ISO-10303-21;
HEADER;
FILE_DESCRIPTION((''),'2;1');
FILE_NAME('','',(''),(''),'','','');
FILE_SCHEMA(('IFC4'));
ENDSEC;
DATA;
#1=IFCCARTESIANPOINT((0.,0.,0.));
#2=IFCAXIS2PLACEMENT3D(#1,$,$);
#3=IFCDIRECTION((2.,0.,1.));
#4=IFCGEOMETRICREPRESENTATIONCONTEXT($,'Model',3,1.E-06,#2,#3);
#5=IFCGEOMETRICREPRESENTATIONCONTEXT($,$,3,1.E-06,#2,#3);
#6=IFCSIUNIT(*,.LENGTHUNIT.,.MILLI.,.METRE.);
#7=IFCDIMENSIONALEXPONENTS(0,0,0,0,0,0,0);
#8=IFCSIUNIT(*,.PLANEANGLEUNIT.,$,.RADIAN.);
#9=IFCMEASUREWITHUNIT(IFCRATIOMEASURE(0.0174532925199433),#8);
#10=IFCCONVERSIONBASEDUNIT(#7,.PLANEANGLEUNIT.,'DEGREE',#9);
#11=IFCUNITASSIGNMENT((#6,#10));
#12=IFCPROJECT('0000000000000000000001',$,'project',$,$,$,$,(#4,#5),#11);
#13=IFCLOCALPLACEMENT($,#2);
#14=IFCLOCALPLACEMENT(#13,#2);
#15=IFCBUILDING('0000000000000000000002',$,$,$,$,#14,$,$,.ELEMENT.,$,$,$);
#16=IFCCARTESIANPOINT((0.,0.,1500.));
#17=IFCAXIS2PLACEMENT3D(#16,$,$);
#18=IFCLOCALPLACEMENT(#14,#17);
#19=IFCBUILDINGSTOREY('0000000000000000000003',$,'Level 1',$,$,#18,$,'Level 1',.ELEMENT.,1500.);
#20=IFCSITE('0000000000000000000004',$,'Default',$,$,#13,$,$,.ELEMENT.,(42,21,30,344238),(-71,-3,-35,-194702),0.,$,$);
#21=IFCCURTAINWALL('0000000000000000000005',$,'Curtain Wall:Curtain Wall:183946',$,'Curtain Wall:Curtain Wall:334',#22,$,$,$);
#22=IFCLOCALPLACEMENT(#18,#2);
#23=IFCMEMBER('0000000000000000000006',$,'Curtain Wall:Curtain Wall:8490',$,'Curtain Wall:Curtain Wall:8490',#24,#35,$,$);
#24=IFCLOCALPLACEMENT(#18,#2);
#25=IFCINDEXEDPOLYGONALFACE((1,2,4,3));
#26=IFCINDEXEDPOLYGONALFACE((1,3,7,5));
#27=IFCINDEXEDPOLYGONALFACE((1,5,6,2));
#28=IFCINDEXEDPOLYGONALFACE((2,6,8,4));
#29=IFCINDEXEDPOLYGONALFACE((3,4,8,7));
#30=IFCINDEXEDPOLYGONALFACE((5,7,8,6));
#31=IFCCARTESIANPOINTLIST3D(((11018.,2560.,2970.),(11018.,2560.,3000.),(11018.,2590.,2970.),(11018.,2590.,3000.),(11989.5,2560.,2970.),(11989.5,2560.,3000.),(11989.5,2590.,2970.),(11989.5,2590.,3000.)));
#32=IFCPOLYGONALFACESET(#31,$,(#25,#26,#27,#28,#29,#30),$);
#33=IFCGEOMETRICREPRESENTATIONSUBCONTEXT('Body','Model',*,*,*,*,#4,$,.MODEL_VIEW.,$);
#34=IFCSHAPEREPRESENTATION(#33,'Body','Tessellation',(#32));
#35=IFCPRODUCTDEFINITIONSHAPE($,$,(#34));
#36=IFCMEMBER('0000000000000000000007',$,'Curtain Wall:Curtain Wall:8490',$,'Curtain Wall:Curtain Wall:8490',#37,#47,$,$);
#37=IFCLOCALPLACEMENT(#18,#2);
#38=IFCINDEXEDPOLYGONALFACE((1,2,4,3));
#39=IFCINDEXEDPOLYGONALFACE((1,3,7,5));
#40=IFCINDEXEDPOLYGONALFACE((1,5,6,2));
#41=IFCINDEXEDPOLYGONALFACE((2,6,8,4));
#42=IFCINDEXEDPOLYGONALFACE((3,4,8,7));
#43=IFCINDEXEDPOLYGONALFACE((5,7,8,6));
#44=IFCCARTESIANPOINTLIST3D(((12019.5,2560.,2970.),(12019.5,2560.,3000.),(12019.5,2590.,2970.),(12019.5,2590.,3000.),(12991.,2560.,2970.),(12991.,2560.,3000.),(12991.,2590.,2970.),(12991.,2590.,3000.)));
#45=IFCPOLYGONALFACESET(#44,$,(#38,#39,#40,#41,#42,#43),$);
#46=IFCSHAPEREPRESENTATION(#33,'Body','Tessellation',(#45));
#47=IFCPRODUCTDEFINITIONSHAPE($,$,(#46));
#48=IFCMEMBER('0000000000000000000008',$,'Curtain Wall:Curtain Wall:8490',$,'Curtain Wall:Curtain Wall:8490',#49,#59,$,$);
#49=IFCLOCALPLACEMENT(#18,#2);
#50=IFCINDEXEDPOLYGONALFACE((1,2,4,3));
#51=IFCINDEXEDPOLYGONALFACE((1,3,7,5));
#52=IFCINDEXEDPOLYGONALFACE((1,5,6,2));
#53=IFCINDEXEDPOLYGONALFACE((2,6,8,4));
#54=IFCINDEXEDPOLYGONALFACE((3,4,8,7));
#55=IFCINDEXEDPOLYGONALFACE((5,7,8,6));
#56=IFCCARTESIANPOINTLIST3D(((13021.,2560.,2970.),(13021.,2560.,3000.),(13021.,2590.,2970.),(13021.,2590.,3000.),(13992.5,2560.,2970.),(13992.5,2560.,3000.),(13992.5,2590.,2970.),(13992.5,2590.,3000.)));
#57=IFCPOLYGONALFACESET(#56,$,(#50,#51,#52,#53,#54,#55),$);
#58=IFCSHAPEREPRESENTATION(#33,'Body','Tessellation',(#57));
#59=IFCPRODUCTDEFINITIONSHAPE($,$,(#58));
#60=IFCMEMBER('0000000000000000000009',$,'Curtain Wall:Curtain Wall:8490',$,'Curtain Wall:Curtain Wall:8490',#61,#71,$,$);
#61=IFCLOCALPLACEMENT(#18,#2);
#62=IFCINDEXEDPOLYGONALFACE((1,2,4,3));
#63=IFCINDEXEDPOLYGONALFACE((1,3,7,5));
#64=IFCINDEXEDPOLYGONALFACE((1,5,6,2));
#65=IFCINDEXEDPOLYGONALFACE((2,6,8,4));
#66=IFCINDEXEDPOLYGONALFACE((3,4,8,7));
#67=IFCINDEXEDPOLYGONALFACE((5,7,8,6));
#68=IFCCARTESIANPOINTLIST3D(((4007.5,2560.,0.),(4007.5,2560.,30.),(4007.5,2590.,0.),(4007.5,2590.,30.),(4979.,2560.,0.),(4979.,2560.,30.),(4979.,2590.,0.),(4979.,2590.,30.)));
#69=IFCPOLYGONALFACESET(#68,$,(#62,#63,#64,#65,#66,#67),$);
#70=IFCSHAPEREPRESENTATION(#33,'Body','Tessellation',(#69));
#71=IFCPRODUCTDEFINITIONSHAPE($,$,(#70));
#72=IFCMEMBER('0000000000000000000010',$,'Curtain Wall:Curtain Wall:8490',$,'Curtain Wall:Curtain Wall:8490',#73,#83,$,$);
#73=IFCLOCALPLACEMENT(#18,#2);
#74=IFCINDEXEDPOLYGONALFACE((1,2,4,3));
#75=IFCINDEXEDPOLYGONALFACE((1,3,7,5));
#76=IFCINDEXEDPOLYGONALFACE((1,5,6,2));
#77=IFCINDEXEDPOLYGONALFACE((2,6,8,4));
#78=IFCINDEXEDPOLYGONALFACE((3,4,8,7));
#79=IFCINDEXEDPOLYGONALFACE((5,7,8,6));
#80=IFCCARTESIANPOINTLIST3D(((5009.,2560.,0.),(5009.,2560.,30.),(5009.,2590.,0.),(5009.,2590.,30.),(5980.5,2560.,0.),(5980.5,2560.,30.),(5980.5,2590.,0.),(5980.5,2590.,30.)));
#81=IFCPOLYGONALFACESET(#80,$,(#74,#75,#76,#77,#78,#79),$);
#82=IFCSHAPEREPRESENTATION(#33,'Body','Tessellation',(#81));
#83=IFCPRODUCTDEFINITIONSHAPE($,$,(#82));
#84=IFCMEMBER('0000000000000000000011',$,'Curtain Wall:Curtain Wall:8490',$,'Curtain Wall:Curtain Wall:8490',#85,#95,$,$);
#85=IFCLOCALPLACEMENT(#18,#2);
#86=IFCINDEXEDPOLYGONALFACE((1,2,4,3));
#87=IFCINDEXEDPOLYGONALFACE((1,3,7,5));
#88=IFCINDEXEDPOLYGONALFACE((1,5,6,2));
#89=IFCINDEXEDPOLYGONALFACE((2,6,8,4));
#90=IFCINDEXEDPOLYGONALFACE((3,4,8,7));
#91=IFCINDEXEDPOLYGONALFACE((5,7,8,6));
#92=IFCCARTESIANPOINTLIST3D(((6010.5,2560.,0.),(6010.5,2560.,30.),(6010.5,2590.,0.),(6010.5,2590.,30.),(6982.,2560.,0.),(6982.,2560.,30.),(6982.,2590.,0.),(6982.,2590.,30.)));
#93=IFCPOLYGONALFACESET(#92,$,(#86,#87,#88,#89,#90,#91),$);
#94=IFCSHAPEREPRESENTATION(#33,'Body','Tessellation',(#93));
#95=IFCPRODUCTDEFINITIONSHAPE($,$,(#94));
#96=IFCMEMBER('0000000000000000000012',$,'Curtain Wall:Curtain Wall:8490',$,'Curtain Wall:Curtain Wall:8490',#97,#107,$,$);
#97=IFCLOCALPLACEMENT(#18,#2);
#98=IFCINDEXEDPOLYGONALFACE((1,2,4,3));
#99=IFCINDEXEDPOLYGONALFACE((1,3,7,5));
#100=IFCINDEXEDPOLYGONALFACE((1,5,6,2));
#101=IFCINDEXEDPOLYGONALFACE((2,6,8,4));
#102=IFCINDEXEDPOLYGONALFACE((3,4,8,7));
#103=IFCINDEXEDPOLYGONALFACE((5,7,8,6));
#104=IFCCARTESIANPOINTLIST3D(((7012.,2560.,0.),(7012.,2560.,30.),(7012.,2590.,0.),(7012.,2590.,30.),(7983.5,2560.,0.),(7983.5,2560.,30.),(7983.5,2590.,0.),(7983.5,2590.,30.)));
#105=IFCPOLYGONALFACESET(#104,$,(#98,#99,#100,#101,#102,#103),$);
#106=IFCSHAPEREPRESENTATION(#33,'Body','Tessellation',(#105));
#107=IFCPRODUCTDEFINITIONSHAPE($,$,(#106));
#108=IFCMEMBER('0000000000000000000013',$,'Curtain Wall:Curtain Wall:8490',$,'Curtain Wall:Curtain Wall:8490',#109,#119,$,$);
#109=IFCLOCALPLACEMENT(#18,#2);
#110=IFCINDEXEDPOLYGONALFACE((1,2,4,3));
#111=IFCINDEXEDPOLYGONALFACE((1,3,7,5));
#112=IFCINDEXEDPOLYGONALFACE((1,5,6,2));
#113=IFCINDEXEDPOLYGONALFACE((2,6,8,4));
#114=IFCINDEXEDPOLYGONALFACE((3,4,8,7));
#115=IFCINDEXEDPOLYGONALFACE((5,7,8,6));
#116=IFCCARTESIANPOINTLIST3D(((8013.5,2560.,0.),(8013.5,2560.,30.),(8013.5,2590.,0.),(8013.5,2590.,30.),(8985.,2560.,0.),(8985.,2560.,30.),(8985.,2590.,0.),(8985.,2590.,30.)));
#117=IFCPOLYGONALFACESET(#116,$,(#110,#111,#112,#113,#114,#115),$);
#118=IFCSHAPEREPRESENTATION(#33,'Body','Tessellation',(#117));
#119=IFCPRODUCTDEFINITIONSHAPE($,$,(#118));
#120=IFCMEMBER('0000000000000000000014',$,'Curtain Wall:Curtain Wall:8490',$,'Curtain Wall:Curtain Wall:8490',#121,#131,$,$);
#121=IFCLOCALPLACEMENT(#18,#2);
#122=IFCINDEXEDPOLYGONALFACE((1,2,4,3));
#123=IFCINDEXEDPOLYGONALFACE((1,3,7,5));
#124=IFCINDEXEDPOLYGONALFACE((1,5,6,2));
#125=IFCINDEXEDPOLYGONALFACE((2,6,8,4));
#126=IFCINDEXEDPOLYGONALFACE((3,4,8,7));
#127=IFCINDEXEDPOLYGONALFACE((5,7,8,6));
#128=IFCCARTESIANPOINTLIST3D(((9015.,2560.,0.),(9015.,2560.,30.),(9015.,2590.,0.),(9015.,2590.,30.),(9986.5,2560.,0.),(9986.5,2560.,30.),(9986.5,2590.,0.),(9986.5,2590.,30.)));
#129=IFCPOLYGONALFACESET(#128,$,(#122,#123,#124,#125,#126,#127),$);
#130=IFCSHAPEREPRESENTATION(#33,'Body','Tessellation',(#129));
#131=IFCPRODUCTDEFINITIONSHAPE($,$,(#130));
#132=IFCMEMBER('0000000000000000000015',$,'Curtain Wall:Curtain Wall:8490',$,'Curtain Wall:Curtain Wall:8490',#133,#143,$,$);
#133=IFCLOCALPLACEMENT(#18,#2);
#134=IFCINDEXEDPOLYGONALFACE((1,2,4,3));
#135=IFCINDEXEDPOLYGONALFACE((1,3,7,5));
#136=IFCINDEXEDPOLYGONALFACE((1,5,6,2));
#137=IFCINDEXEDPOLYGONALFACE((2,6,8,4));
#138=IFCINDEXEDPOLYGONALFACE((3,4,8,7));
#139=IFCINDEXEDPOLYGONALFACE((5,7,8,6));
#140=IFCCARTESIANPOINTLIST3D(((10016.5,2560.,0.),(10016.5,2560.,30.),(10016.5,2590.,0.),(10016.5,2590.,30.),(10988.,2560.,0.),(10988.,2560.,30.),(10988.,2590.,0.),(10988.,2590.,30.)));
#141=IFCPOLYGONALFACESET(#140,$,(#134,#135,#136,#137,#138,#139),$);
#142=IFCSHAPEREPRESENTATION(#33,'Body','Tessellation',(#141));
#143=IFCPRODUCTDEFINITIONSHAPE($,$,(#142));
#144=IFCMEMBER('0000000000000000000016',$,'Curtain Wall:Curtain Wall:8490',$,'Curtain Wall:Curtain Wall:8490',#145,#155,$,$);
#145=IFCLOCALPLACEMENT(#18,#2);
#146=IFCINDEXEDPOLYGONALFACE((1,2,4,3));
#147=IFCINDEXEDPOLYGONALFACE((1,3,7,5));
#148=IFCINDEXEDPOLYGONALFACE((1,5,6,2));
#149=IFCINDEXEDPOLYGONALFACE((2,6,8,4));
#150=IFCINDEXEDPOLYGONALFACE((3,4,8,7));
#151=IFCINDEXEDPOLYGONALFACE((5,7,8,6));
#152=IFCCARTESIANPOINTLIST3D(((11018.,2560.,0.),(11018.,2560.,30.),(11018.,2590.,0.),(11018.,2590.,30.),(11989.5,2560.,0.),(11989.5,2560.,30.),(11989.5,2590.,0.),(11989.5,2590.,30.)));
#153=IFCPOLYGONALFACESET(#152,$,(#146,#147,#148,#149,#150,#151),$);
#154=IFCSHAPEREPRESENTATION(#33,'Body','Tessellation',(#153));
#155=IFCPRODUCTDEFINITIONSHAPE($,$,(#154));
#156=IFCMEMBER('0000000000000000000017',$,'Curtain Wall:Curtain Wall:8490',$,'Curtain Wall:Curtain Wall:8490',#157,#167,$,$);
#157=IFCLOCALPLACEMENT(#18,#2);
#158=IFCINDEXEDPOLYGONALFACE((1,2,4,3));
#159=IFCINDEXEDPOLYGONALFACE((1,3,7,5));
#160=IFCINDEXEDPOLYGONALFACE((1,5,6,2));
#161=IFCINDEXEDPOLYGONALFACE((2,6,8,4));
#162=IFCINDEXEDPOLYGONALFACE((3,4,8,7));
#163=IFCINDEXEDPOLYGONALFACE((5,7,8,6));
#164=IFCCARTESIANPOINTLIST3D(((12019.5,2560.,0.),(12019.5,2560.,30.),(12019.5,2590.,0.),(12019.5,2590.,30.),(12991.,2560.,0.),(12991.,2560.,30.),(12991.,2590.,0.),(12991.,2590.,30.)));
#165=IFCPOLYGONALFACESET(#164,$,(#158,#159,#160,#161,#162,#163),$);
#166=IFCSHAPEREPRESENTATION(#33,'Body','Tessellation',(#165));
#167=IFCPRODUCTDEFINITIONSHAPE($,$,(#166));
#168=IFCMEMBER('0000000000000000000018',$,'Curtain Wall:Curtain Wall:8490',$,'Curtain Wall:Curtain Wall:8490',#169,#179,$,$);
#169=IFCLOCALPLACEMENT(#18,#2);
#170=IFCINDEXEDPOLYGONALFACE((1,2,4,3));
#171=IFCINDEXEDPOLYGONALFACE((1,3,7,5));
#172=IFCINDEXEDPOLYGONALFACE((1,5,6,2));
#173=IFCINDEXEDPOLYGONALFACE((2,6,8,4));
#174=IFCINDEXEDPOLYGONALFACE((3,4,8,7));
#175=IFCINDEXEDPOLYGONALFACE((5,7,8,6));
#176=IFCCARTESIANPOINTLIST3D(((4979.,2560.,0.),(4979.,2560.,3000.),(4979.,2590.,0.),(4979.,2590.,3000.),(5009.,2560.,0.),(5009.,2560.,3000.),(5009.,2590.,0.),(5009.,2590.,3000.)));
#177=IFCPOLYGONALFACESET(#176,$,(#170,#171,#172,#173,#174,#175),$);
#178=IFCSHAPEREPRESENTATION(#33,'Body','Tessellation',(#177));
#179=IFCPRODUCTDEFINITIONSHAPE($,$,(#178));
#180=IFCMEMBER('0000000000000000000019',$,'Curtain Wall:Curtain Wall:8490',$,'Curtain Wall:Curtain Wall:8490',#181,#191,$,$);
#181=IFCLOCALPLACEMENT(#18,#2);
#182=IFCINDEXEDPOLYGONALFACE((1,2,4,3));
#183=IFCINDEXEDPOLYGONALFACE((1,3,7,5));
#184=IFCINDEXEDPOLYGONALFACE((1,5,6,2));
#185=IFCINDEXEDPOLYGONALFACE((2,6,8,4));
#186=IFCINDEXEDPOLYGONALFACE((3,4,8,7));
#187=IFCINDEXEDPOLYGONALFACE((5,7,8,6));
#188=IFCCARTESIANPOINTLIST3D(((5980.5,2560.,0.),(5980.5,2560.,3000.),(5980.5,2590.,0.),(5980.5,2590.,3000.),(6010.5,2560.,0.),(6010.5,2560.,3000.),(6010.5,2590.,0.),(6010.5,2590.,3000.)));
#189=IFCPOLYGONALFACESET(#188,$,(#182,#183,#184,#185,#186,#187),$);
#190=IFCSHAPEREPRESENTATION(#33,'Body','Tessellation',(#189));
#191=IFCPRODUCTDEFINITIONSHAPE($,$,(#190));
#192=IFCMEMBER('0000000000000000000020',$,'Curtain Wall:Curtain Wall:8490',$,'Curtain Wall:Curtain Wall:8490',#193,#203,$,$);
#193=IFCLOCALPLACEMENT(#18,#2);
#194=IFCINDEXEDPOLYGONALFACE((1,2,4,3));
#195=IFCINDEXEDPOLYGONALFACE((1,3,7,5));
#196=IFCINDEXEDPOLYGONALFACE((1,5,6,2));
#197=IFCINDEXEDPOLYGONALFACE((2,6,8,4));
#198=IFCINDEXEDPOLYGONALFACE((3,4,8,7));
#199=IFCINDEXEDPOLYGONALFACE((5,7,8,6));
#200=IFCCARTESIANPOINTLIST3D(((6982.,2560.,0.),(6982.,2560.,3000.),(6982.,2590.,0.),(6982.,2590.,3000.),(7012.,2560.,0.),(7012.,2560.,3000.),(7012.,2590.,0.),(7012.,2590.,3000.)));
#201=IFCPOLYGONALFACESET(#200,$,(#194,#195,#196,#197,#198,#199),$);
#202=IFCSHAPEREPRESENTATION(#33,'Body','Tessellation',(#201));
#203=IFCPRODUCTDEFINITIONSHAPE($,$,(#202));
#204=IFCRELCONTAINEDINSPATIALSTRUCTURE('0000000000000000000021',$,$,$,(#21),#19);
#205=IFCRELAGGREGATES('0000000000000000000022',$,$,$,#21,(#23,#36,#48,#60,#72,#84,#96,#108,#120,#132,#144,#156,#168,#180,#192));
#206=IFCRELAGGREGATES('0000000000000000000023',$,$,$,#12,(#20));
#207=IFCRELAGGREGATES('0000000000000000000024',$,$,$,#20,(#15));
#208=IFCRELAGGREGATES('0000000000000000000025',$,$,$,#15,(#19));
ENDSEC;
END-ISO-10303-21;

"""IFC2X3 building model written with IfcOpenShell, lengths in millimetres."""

from ifc_helpers import new_model, entity, si_unit, converted_unit, direction, frame, frame_2d, origin, place, context, subcontext, project, spatial, rectangle, extrude, element, aggregate, save


model = new_model("IFC2X3")

# Units and contexts
model_context = context("Model", 3, precision=1e-06, world=origin(), true_north=direction((2.0, 0.0, 1.0)))
context_of_model = context(None, 3, precision=1e-06, world=origin(), true_north=direction((2.0, 0.0, 1.0)))
body_context = subcontext(model_context, "Body", "Model", "MODEL_VIEW")
ifc_project = project(units=[si_unit("LENGTHUNIT", "METRE", prefix="MILLI"), converted_unit("PLANEANGLEUNIT", "DEGREE", entity("IfcRatioMeasure", 0.0174532925199433), si_unit("PLANEANGLEUNIT", "RADIAN"), dimensions=[0, 0, 0, 0, 0, 0, 0])], contexts=[model_context, context_of_model])

# Site, building, storey
site_placement = place(None, origin())
site = spatial("IfcSite", under=ifc_project, at=site_placement, Name="Default", CompositionType="ELEMENT", RefLatitude=(42, 21, 30, 344238), RefLongitude=(-71, -3, -35, -194702), RefElevation=0.0)
building_placement = place(site_placement, origin())
building = spatial("IfcBuilding", under=site, at=building_placement, CompositionType="ELEMENT")
storey_placement = place(building_placement, frame((0.0, 0.0, 1500.0)))
storey = spatial("IfcBuildingStorey", under=building, at=storey_placement, Name="Level 1", LongName="Level 1", CompositionType="ELEMENT", Elevation=1500.0)

# Curtain wall, members
curtain_wall_1_placement = place(storey_placement, origin())
curtain_wall_1 = element("IfcCurtainWall", 1, at=curtain_wall_1_placement, inside=storey, Name="Curtain Wall:Curtain Wall:183946", ObjectType="Curtain Wall:Curtain Wall:334")
member_1_placement = place(storey_placement, origin())
member_1 = element("IfcMember", 2, at=member_1_placement, Name="Curtain Wall:Curtain Wall:8490", ObjectType="Curtain Wall:Curtain Wall:8490", context=body_context, shape_type="SweptSolid", body=[
    extrude(rectangle(XDim=971.5, YDim=30.0, at=frame_2d((0.0, 0.0), x_axis=(1.0, 0.0))), frame((11503.8, 2575.0, 2970.0)), (0.0, 0.0, 1.0), 30.0),
])
member_2_placement = place(storey_placement, origin())
member_2 = element("IfcMember", 3, at=member_2_placement, Name="Curtain Wall:Curtain Wall:8490", ObjectType="Curtain Wall:Curtain Wall:8490", context=body_context, shape_type="SweptSolid", body=[
    extrude(rectangle(XDim=971.5, YDim=30.0, at=frame_2d((0.0, 0.0), x_axis=(1.0, 0.0))), frame((12505.2, 2575.0, 2970.0)), (0.0, 0.0, 1.0), 30.0),
])
member_3_placement = place(storey_placement, origin())
member_3 = element("IfcMember", 4, at=member_3_placement, Name="Curtain Wall:Curtain Wall:8490", ObjectType="Curtain Wall:Curtain Wall:8490", context=body_context, shape_type="SweptSolid", body=[
    extrude(rectangle(XDim=971.5, YDim=30.0, at=frame_2d((0.0, 0.0), x_axis=(1.0, 0.0))), frame((13506.8, 2575.0, 2970.0)), (0.0, 0.0, 1.0), 30.0),
])
member_4_placement = place(storey_placement, origin())
member_4 = element("IfcMember", 5, at=member_4_placement, Name="Curtain Wall:Curtain Wall:8490", ObjectType="Curtain Wall:Curtain Wall:8490", context=body_context, shape_type="SweptSolid", body=[
    extrude(rectangle(XDim=971.5, YDim=30.0, at=frame_2d((0.0, 0.0), x_axis=(1.0, 0.0))), frame((4493.2, 2575.0, 0.0), z_axis=(0.0, 0.0, 1.0), x_axis=(-1.0, 0.0, 0.0)), (0.0, 0.0, 1.0), 30.0),
])
member_5_placement = place(storey_placement, origin())
member_5 = element("IfcMember", 6, at=member_5_placement, Name="Curtain Wall:Curtain Wall:8490", ObjectType="Curtain Wall:Curtain Wall:8490", context=body_context, shape_type="SweptSolid", body=[
    extrude(rectangle(XDim=971.5, YDim=30.0, at=frame_2d((0.0, 0.0), x_axis=(1.0, 0.0))), frame((5494.8, 2575.0, 0.0), z_axis=(0.0, 0.0, 1.0), x_axis=(-1.0, 0.0, 0.0)), (0.0, 0.0, 1.0), 30.0),
])
member_6_placement = place(storey_placement, origin())
member_6 = element("IfcMember", 7, at=member_6_placement, Name="Curtain Wall:Curtain Wall:8490", ObjectType="Curtain Wall:Curtain Wall:8490", context=body_context, shape_type="SweptSolid", body=[
    extrude(rectangle(XDim=971.5, YDim=30.0, at=frame_2d((0.0, 0.0), x_axis=(1.0, 0.0))), frame((6496.2, 2575.0, 0.0), z_axis=(0.0, 0.0, 1.0), x_axis=(-1.0, 0.0, 0.0)), (0.0, 0.0, 1.0), 30.0),
])
member_7_placement = place(storey_placement, origin())
member_7 = element("IfcMember", 8, at=member_7_placement, Name="Curtain Wall:Curtain Wall:8490", ObjectType="Curtain Wall:Curtain Wall:8490", context=body_context, shape_type="SweptSolid", body=[
    extrude(rectangle(XDim=971.5, YDim=30.0, at=frame_2d((0.0, 0.0), x_axis=(1.0, 0.0))), frame((7497.8, 2575.0, 0.0), z_axis=(0.0, 0.0, 1.0), x_axis=(-1.0, 0.0, 0.0)), (0.0, 0.0, 1.0), 30.0),
])
member_8_placement = place(storey_placement, origin())
member_8 = element("IfcMember", 9, at=member_8_placement, Name="Curtain Wall:Curtain Wall:8490", ObjectType="Curtain Wall:Curtain Wall:8490", context=body_context, shape_type="SweptSolid", body=[
    extrude(rectangle(XDim=971.5, YDim=30.0, at=frame_2d((0.0, 0.0), x_axis=(1.0, 0.0))), frame((8499.2, 2575.0, 0.0), z_axis=(0.0, 0.0, 1.0), x_axis=(-1.0, 0.0, 0.0)), (0.0, 0.0, 1.0), 30.0),
])
member_9_placement = place(storey_placement, origin())
member_9 = element("IfcMember", 10, at=member_9_placement, Name="Curtain Wall:Curtain Wall:8490", ObjectType="Curtain Wall:Curtain Wall:8490", context=body_context, shape_type="SweptSolid", body=[
    extrude(rectangle(XDim=971.5, YDim=30.0, at=frame_2d((0.0, 0.0), x_axis=(1.0, 0.0))), frame((9500.8, 2575.0, 0.0), z_axis=(0.0, 0.0, 1.0), x_axis=(-1.0, 0.0, 0.0)), (0.0, 0.0, 1.0), 30.0),
])
member_10_placement = place(storey_placement, origin())
member_10 = element("IfcMember", 11, at=member_10_placement, Name="Curtain Wall:Curtain Wall:8490", ObjectType="Curtain Wall:Curtain Wall:8490", context=body_context, shape_type="SweptSolid", body=[
    extrude(rectangle(XDim=971.5, YDim=30.0, at=frame_2d((0.0, 0.0), x_axis=(1.0, 0.0))), frame((10502.2, 2575.0, 0.0), z_axis=(0.0, 0.0, 1.0), x_axis=(-1.0, 0.0, 0.0)), (0.0, 0.0, 1.0), 30.0),
])
member_11_placement = place(storey_placement, origin())
member_11 = element("IfcMember", 12, at=member_11_placement, Name="Curtain Wall:Curtain Wall:8490", ObjectType="Curtain Wall:Curtain Wall:8490", context=body_context, shape_type="SweptSolid", body=[
    extrude(rectangle(XDim=971.5, YDim=30.0, at=frame_2d((0.0, 0.0), x_axis=(1.0, 0.0))), frame((11503.8, 2575.0, 0.0), z_axis=(0.0, 0.0, 1.0), x_axis=(-1.0, 0.0, 0.0)), (0.0, 0.0, 1.0), 30.0),
])
member_12_placement = place(storey_placement, origin())
member_12 = element("IfcMember", 13, at=member_12_placement, Name="Curtain Wall:Curtain Wall:8490", ObjectType="Curtain Wall:Curtain Wall:8490", context=body_context, shape_type="SweptSolid", body=[
    extrude(rectangle(XDim=971.5, YDim=30.0, at=frame_2d((0.0, 0.0), x_axis=(1.0, 0.0))), frame((12505.2, 2575.0, 0.0), z_axis=(0.0, 0.0, 1.0), x_axis=(-1.0, 0.0, 0.0)), (0.0, 0.0, 1.0), 30.0),
])
member_13_placement = place(storey_placement, origin())
member_13 = element("IfcMember", 14, at=member_13_placement, Name="Curtain Wall:Curtain Wall:8490", ObjectType="Curtain Wall:Curtain Wall:8490", context=body_context, shape_type="SweptSolid", body=[
    extrude(rectangle(XDim=30.0, YDim=30.0, at=frame_2d((0.0, 0.0), x_axis=(1.0, 0.0))), frame((4994.0, 2575.0, 0.0), z_axis=(0.0, 0.0, 1.0), x_axis=(0.0, -1.0, 0.0)), (0.0, 0.0, 1.0), 3000.0),
])
member_14_placement = place(storey_placement, origin())
member_14 = element("IfcMember", 15, at=member_14_placement, Name="Curtain Wall:Curtain Wall:8490", ObjectType="Curtain Wall:Curtain Wall:8490", context=body_context, shape_type="SweptSolid", body=[
    extrude(rectangle(XDim=30.0, YDim=30.0, at=frame_2d((0.0, 0.0), x_axis=(1.0, 0.0))), frame((5995.5, 2575.0, 0.0), z_axis=(0.0, 0.0, 1.0), x_axis=(0.0, -1.0, 0.0)), (0.0, 0.0, 1.0), 3000.0),
])
member_15_placement = place(storey_placement, origin())
member_15 = element("IfcMember", 16, at=member_15_placement, Name="Curtain Wall:Curtain Wall:8490", ObjectType="Curtain Wall:Curtain Wall:8490", context=body_context, shape_type="SweptSolid", body=[
    extrude(rectangle(XDim=30.0, YDim=30.0, at=frame_2d((0.0, 0.0), x_axis=(1.0, 0.0))), frame((6997.0, 2575.0, 0.0), z_axis=(0.0, 0.0, 1.0), x_axis=(0.0, -1.0, 0.0)), (0.0, 0.0, 1.0), 3000.0),
])
aggregate(curtain_wall_1, [member_1, member_2, member_3, member_4, member_5, member_6, member_7, member_8, member_9, member_10, member_11, member_12, member_13, member_14, member_15])

save(model, "model.ifc")
